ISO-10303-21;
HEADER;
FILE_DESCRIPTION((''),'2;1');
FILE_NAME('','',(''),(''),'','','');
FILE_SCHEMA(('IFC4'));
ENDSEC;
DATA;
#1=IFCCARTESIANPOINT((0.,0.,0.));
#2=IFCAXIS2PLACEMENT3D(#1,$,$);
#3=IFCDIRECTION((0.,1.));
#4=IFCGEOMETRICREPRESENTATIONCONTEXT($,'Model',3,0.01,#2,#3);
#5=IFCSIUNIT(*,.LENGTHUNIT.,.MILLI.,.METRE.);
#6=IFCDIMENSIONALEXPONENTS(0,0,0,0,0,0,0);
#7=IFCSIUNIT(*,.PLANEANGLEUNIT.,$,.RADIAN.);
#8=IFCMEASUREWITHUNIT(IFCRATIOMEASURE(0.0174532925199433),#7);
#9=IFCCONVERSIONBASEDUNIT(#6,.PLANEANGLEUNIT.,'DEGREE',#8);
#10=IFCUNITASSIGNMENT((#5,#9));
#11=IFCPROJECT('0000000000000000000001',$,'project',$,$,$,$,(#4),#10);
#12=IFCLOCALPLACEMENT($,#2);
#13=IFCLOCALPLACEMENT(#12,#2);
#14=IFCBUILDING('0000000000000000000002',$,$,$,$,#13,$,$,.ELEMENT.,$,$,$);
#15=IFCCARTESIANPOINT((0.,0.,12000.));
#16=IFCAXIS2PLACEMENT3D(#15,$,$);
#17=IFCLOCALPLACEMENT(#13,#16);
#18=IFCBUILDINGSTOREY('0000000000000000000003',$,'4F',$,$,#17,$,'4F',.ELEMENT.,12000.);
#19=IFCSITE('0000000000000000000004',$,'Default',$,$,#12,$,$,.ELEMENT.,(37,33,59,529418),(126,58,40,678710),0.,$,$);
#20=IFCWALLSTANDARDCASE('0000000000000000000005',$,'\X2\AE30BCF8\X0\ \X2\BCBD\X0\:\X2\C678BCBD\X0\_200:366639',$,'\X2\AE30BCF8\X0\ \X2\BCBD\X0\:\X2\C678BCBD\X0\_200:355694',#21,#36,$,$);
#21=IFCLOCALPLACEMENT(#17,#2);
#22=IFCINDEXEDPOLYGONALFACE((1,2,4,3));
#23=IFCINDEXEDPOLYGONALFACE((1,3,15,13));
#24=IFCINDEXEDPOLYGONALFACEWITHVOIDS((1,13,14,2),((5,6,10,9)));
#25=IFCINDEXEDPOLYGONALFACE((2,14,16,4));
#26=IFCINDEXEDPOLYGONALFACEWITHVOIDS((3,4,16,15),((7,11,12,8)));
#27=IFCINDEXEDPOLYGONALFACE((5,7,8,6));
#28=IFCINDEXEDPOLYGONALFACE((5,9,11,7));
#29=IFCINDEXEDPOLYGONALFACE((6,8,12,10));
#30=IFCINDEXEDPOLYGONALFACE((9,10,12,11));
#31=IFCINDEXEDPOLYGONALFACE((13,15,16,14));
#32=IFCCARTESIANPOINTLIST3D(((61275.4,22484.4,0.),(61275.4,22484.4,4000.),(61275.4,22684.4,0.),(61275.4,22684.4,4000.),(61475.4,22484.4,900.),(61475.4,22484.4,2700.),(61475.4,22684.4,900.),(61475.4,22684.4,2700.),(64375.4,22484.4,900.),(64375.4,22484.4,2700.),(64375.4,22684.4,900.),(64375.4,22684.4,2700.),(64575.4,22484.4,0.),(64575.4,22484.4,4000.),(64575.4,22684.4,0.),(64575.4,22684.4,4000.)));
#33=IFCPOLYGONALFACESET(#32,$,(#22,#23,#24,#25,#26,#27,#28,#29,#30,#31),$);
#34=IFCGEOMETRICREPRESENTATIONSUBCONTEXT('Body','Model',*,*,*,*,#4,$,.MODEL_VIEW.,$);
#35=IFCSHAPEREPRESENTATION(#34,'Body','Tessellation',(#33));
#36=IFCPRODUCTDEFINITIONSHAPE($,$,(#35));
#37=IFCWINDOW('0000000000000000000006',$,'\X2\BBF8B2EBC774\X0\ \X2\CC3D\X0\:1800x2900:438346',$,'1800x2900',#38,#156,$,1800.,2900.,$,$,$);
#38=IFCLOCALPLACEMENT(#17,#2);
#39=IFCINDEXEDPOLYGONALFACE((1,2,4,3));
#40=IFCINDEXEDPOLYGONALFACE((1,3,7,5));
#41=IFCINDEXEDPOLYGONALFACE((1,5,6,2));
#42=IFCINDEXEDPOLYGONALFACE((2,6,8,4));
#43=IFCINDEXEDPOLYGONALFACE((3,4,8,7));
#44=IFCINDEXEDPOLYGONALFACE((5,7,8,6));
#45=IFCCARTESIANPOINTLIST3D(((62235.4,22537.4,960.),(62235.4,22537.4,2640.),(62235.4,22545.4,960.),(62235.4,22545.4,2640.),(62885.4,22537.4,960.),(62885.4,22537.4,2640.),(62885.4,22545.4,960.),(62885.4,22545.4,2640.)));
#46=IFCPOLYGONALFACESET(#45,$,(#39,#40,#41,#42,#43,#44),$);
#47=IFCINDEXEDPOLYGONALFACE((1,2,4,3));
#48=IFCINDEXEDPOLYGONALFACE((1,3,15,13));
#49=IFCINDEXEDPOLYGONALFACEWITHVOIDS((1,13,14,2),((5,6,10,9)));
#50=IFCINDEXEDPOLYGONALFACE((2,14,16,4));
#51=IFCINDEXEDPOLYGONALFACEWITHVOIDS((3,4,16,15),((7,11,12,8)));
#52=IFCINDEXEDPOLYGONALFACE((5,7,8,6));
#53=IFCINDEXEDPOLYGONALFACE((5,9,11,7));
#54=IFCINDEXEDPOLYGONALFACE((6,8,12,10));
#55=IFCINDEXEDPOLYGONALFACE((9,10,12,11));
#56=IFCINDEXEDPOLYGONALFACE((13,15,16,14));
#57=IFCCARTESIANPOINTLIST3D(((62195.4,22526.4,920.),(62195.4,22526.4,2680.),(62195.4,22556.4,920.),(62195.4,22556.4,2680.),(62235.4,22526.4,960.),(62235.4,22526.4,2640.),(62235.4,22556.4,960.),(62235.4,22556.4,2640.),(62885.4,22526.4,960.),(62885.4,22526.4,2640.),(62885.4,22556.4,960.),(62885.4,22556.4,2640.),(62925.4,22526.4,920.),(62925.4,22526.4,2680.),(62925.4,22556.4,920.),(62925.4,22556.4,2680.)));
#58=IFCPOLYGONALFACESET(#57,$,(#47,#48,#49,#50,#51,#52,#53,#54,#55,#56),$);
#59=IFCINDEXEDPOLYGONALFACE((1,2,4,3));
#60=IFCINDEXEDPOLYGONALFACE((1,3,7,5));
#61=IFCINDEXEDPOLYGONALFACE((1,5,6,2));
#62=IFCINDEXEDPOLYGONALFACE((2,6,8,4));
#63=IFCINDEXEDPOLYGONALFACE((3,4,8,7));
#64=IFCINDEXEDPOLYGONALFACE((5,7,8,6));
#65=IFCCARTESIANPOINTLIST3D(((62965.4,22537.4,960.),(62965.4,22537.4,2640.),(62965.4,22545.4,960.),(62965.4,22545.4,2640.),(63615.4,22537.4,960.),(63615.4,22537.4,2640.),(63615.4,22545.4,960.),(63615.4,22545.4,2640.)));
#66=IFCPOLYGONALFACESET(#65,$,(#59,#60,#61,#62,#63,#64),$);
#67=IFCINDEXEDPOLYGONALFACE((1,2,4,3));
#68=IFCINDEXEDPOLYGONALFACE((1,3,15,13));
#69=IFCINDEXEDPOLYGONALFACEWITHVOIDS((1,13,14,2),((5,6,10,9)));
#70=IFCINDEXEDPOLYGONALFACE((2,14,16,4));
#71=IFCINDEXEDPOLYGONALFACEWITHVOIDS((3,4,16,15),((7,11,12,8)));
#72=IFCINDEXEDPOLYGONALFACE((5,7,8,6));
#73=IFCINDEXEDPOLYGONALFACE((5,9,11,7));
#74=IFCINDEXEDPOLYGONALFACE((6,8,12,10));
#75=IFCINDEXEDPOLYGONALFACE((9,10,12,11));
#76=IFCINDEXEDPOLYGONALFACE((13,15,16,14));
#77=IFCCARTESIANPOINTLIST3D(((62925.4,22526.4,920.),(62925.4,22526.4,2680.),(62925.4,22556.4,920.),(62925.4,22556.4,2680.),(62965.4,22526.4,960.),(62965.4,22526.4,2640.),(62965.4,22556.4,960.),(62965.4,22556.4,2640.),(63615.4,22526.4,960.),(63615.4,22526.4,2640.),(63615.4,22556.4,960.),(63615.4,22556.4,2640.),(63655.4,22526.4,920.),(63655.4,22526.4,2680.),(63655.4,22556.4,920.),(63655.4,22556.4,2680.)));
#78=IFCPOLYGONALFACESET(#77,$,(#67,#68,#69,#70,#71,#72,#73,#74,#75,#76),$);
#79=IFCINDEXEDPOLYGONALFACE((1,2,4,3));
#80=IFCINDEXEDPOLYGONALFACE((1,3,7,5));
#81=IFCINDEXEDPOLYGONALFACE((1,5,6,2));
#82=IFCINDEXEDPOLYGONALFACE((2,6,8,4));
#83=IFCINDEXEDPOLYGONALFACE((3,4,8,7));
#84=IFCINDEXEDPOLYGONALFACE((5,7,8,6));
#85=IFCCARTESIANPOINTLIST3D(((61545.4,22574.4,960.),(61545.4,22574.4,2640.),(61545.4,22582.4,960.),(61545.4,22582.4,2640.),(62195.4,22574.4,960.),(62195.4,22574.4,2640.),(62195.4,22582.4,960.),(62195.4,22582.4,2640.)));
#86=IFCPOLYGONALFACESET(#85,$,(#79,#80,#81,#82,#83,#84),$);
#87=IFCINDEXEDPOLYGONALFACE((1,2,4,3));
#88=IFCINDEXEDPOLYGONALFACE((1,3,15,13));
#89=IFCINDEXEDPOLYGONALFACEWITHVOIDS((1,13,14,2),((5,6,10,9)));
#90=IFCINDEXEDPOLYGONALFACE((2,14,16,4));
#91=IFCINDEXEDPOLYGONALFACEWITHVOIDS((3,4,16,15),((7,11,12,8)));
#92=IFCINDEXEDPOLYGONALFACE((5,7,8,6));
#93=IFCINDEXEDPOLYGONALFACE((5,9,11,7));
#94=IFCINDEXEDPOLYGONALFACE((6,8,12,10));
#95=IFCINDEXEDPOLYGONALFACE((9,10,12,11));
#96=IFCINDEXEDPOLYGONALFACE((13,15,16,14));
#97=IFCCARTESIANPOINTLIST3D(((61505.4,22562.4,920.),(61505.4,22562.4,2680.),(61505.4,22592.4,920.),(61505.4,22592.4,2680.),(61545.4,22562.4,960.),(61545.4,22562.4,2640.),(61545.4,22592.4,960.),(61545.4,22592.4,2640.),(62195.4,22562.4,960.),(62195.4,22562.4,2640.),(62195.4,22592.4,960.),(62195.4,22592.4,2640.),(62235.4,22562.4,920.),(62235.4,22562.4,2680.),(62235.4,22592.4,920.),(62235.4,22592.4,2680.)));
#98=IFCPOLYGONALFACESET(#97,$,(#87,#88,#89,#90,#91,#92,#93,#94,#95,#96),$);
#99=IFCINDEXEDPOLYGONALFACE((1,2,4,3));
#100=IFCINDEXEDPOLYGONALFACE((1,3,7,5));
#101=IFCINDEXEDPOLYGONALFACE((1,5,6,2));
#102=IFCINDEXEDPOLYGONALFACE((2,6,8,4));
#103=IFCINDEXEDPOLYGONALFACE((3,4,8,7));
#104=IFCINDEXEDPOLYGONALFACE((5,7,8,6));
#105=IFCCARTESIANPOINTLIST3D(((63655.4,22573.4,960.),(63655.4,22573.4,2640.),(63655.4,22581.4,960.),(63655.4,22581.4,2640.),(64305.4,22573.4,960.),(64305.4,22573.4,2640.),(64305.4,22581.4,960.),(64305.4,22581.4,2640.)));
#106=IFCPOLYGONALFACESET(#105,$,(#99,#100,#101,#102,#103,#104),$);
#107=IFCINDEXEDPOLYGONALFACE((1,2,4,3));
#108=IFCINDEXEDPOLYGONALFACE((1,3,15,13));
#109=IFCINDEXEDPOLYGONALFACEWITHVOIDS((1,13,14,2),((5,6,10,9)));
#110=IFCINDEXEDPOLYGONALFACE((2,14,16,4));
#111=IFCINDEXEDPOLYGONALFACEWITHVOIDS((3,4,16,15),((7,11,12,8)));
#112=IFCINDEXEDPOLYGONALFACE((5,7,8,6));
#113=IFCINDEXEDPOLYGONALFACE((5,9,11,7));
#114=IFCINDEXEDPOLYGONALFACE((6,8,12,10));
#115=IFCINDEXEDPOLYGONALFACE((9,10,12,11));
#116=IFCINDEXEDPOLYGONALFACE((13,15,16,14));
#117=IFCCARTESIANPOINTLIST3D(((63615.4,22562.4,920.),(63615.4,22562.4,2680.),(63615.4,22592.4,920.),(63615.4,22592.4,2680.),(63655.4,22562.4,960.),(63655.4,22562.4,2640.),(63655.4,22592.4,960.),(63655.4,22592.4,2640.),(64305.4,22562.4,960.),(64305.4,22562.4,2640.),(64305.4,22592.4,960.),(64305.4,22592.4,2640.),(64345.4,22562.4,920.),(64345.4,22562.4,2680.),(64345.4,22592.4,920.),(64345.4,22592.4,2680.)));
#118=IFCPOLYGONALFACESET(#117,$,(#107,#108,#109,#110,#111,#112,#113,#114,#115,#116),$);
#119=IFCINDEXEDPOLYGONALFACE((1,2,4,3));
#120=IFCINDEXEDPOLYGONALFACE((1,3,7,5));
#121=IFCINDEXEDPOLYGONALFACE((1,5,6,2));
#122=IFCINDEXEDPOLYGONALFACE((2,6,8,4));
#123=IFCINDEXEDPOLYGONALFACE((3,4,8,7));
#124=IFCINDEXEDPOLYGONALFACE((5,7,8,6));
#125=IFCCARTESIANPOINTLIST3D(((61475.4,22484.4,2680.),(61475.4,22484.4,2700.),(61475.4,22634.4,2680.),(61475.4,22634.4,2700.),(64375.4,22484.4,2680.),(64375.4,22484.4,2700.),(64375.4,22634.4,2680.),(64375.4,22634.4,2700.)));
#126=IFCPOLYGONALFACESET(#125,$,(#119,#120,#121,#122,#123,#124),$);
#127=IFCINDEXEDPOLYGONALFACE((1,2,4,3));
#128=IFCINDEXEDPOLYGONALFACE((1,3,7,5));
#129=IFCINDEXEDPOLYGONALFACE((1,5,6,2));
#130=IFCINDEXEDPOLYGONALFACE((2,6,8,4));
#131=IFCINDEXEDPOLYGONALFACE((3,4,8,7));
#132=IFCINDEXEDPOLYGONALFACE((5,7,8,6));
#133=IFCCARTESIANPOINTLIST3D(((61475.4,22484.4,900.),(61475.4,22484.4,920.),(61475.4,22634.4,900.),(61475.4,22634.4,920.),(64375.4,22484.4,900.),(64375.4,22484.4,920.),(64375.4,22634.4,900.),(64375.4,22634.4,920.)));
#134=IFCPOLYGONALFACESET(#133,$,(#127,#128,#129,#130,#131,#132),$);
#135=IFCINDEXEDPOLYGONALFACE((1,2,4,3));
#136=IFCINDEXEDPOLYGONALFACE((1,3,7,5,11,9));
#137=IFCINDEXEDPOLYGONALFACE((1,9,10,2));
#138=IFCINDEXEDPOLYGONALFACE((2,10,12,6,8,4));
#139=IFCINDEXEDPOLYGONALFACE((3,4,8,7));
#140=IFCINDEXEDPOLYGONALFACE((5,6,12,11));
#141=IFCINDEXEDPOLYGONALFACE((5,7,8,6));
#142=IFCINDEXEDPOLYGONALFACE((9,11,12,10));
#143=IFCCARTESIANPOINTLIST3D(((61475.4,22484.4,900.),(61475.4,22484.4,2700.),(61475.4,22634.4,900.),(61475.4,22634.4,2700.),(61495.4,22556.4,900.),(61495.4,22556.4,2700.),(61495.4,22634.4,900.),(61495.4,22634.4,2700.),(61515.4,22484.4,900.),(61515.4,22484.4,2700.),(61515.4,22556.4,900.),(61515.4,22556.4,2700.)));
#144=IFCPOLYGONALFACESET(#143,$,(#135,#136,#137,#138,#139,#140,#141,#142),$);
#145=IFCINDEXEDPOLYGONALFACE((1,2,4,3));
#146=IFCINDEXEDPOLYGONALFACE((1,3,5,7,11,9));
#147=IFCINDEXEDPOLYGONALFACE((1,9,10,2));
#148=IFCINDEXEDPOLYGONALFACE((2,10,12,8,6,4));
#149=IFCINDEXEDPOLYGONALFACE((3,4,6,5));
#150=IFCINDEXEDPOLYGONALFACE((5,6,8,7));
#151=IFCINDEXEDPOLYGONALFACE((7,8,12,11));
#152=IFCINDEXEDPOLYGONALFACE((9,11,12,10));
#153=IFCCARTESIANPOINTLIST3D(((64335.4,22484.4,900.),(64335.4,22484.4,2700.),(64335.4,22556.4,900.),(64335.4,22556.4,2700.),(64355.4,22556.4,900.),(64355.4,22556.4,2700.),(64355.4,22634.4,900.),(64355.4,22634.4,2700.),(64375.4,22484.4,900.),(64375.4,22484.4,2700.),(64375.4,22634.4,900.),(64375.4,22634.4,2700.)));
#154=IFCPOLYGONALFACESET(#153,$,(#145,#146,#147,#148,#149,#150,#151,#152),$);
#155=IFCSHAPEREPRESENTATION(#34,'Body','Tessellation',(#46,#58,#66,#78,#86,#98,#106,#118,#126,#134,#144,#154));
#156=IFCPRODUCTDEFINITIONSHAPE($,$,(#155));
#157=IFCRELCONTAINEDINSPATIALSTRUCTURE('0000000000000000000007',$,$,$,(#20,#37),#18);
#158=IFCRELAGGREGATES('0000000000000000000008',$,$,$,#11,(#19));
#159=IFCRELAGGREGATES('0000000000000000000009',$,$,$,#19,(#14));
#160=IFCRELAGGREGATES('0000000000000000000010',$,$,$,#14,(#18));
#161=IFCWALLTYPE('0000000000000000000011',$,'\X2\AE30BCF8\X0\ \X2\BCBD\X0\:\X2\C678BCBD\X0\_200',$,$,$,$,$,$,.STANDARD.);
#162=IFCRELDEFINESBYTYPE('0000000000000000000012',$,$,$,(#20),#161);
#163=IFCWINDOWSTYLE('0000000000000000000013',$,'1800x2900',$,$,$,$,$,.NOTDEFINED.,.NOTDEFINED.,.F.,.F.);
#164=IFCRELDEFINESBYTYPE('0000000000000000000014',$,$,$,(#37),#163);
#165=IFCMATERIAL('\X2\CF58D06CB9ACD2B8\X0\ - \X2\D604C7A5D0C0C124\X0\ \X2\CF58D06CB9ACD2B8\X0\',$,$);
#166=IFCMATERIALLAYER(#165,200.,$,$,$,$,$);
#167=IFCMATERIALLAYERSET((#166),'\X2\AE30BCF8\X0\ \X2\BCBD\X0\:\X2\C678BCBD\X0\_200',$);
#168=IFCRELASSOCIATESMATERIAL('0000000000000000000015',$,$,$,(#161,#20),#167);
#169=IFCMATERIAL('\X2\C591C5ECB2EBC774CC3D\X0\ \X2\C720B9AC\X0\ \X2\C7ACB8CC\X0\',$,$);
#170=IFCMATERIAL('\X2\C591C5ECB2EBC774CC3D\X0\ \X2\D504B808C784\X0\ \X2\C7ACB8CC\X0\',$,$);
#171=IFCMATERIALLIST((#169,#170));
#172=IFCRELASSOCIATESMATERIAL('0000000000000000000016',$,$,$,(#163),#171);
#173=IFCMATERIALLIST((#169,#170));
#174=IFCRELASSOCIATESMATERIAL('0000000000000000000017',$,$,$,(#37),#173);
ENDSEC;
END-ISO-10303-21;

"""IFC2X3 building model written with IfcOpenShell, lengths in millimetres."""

from ifc_helpers import new_model, entity, si_unit, converted_unit, direction, frame, frame_2d, origin, origin_2d_with_axis, place, context, subcontext, project, spatial, polyline, rectangle, outline, extrude, source, transform, mapped, material, material_list, layer, layer_set, layer_usage, type_object, type_shapes, element, fill, save


model = new_model("IFC2X3")

# Units and contexts
model_context = context("Model", 3, precision=0.01, world=origin(), true_north=direction((0.0, 1.0)))
body_context = subcontext(model_context, "Body", "Model", "MODEL_VIEW")
ifc_project = project(units=[si_unit("LENGTHUNIT", "METRE", prefix="MILLI"), converted_unit("PLANEANGLEUNIT", "DEGREE", entity("IfcRatioMeasure", 0.0174532925199433), si_unit("PLANEANGLEUNIT", "RADIAN"), dimensions=[0, 0, 0, 0, 0, 0, 0])], contexts=[model_context])

# Site, building, storey
site_placement = place(None, origin())
site = spatial("IfcSite", under=ifc_project, at=site_placement, Name="Default", CompositionType="ELEMENT", RefLatitude=(37, 33, 59, 529418), RefLongitude=(126, 58, 40, 678710), RefElevation=0.0)
building_placement = place(site_placement, origin())
building = spatial("IfcBuilding", under=site, at=building_placement, CompositionType="ELEMENT")
storey_placement = place(building_placement, frame((0.0, 0.0, 12000.0)))
storey = spatial("IfcBuildingStorey", under=building, at=storey_placement, Name="4F", LongName="4F", CompositionType="ELEMENT", Elevation=12000.0)

# Wall, opening, window
ifc_material_1 = material(Name="콘크리트 - 현장타설 콘크리트")
ifc_layer_1 = layer(ifc_material_1, 200.0)
ifc_layer_set_1 = layer_set([ifc_layer_1], Name="기본 벽:외벽_200")
wall_type_1 = type_object("IfcWallType", Name="기본 벽:외벽_200", PredefinedType="STANDARD", material=ifc_layer_set_1)
ifc_material_2 = material(Name="양여닫이창 유리 재료")
ifc_material_3 = material(Name="양여닫이창 프레임 재료")
ifc_material_list_1 = material_list([ifc_material_2, ifc_material_3])
window_style = type_object("IfcWindowStyle", Name="1800x2900", ConstructionType="NOTDEFINED", OperationType="NOTDEFINED", ParameterTakesPrecedence=False, Sizeable=False, material=ifc_material_list_1)
shared_shape_1 = source(origin(), body_context, "Body", "SweptSolid", [
    extrude(rectangle(XDim=8.0, YDim=650.0, at=frame_2d((0.0, 0.0), x_axis=(1.0, 0.0))), frame((1815.0, 143.0, 60.0), z_axis=(0.0, 0.0, 1.0), x_axis=(0.0, 1.0, 0.0)), (0.0, 0.0, 1.0), 1680.0),
    extrude(outline(polyline([(-880.0, -365.0), (880.0, -365.0), (880.0, 365.0), (-880.0, 365.0), (-880.0, -365.0)]), holes=[polyline([(840.0, -325.0), (-840.0, -325.0), (-840.0, 325.0), (840.0, 325.0), (840.0, -325.0)])]), frame((1815.0, 128.0, 900.0), z_axis=(0.0, 1.0, 0.0), x_axis=(0.0, 0.0, -1.0)), (0.0, 0.0, 1.0), 30.0),
    extrude(rectangle(XDim=8.0, YDim=650.0, at=frame_2d((0.0, 0.0), x_axis=(1.0, 0.0))), frame((1085.0, 143.0, 60.0), z_axis=(0.0, 0.0, 1.0), x_axis=(0.0, 1.0, 0.0)), (0.0, 0.0, 1.0), 1680.0),
    extrude(outline(polyline([(-880.0, -365.0), (880.0, -365.0), (880.0, 365.0), (-880.0, 365.0), (-880.0, -365.0)]), holes=[polyline([(840.0, -325.0), (-840.0, -325.0), (-840.0, 325.0), (840.0, 325.0), (840.0, -325.0)])]), frame((1085.0, 128.0, 900.0), z_axis=(0.0, 1.0, 0.0), x_axis=(0.0, 0.0, -1.0)), (0.0, 0.0, 1.0), 30.0),
    extrude(rectangle(XDim=8.0, YDim=650.0, at=frame_2d((0.0, 0.0), x_axis=(1.0, 0.0))), frame((2505.0, 106.0, 60.0), z_axis=(0.0, 0.0, 1.0), x_axis=(0.0, 1.0, 0.0)), (0.0, 0.0, 1.0), 1680.0),
    extrude(outline(polyline([(-880.0, -365.0), (880.0, -365.0), (880.0, 365.0), (-880.0, 365.0), (-880.0, -365.0)]), holes=[polyline([(840.0, -325.0), (-840.0, -325.0), (-840.0, 325.0), (840.0, 325.0), (840.0, -325.0)])]), frame((2505.0, 92.0, 900.0), z_axis=(0.0, 1.0, 0.0), x_axis=(0.0, 0.0, -1.0)), (0.0, 0.0, 1.0), 30.0),
    extrude(rectangle(XDim=8.0, YDim=650.0, at=origin_2d_with_axis()), frame((395.0, 107.0, 60.0), z_axis=(0.0, 0.0, 1.0), x_axis=(0.0, 1.0, 0.0)), (0.0, 0.0, 1.0), 1680.0),
    extrude(outline(polyline([(-880.0, -365.0), (880.0, -365.0), (880.0, 365.0), (-880.0, 365.0), (-880.0, -365.0)]), holes=[polyline([(840.0, -325.0), (-840.0, -325.0), (-840.0, 325.0), (840.0, 325.0), (840.0, -325.0)])]), frame((395.0, 92.0, 900.0), z_axis=(0.0, 1.0, 0.0), x_axis=(0.0, 0.0, -1.0)), (0.0, 0.0, 1.0), 30.0),
    extrude(rectangle(XDim=2900.0, YDim=150.0, at=origin_2d_with_axis()), frame((1450.0, 125.0, 1780.0), z_axis=(0.0, 0.0, 1.0), x_axis=(-1.0, 0.0, 0.0)), (0.0, 0.0, 1.0), 20.0),
    extrude(rectangle(XDim=2900.0, YDim=150.0, at=origin_2d_with_axis()), frame((1450.0, 125.0, 0.0), z_axis=(0.0, 0.0, 1.0), x_axis=(-1.0, 0.0, 0.0)), (0.0, 0.0, 1.0), 20.0),
    extrude(outline(polyline([(-74.0, -20.0), (-2.0, -20.0), (-2.0, 0.0), (76.0, 0.0), (76.0, 20.0), (-74.0, 20.0), (-74.0, -20.0)])), frame((2880.0, 126.0, 0.0), z_axis=(0.0, 0.0, 1.0), x_axis=(0.0, -1.0, 0.0)), (0.0, 0.0, 1.0), 1800.0),
    extrude(outline(polyline([(-20.0, -74.0), (20.0, -74.0), (20.0, 76.0), (0.0, 76.0), (0.0, -2.0), (-20.0, -2.0), (-20.0, -74.0)])), frame((20.0, 126.0, 0.0), z_axis=(0.0, 0.0, 1.0), x_axis=(-1.0, 0.0, 0.0)), (0.0, 0.0, 1.0), 1800.0),
])
type_shapes(window_style, [shared_shape_1])
ifc_layer_usage_1 = layer_usage(ifc_layer_set_1, "AXIS2", "NEGATIVE", 100.0)
wall_1_placement = place(storey_placement, frame((64575.4, 22584.4, 0.0), z_axis=(0.0, 0.0, 1.0), x_axis=(-1.0, 0.0, 0.0)))
wall_1 = element("IfcWallStandardCase", 1, at=wall_1_placement, inside=storey, type_object=wall_type_1, material=ifc_layer_usage_1, Name="기본 벽:외벽_200:366639", ObjectType="기본 벽:외벽_200:355694", context=body_context, shape_type="SweptSolid", body=[
    extrude(rectangle(XDim=3300.0, YDim=200.0, at=frame_2d((1650.0, 0.0), x_axis=(-1.0, 0.0))), origin(), (0.0, 0.0, 1.0), 4000.0),
])
opening_1_placement = place(wall_1_placement, frame((200.0, -100.0, 900.0)))
opening_1 = element("IfcOpeningElement", 2, at=opening_1_placement, cuts=wall_1, ObjectType="Opening", context=body_context, shape_type="SweptSolid", body=[
    extrude(rectangle(XDim=1800.0, YDim=2900.0, at=frame_2d((900.0, 1450.0), x_axis=(1.0, 0.0))), frame((0.0, 0.0, 0.0), z_axis=(0.0, 1.0, 0.0), x_axis=(0.0, 0.0, 1.0)), (0.0, 0.0, 1.0), 200.0),
])
ifc_material_list_2 = material_list([ifc_material_2, ifc_material_3])
window_1_placement = place(opening_1_placement, origin())
window_1 = element("IfcWindow", 3, at=window_1_placement, inside=storey, type_object=window_style, material=ifc_material_list_2, Name="미닫이 창:1800x2900:438346", ObjectType="1800x2900", OverallHeight=1800.0, OverallWidth=2900.0, context=body_context, shape_type="MappedRepresentation", body=[
    mapped(shared_shape_1, transform((0.0, 0.0, 0.0), scale=1.0)),
])
fill(opening_1, window_1)

save(model, "model.ifc")
